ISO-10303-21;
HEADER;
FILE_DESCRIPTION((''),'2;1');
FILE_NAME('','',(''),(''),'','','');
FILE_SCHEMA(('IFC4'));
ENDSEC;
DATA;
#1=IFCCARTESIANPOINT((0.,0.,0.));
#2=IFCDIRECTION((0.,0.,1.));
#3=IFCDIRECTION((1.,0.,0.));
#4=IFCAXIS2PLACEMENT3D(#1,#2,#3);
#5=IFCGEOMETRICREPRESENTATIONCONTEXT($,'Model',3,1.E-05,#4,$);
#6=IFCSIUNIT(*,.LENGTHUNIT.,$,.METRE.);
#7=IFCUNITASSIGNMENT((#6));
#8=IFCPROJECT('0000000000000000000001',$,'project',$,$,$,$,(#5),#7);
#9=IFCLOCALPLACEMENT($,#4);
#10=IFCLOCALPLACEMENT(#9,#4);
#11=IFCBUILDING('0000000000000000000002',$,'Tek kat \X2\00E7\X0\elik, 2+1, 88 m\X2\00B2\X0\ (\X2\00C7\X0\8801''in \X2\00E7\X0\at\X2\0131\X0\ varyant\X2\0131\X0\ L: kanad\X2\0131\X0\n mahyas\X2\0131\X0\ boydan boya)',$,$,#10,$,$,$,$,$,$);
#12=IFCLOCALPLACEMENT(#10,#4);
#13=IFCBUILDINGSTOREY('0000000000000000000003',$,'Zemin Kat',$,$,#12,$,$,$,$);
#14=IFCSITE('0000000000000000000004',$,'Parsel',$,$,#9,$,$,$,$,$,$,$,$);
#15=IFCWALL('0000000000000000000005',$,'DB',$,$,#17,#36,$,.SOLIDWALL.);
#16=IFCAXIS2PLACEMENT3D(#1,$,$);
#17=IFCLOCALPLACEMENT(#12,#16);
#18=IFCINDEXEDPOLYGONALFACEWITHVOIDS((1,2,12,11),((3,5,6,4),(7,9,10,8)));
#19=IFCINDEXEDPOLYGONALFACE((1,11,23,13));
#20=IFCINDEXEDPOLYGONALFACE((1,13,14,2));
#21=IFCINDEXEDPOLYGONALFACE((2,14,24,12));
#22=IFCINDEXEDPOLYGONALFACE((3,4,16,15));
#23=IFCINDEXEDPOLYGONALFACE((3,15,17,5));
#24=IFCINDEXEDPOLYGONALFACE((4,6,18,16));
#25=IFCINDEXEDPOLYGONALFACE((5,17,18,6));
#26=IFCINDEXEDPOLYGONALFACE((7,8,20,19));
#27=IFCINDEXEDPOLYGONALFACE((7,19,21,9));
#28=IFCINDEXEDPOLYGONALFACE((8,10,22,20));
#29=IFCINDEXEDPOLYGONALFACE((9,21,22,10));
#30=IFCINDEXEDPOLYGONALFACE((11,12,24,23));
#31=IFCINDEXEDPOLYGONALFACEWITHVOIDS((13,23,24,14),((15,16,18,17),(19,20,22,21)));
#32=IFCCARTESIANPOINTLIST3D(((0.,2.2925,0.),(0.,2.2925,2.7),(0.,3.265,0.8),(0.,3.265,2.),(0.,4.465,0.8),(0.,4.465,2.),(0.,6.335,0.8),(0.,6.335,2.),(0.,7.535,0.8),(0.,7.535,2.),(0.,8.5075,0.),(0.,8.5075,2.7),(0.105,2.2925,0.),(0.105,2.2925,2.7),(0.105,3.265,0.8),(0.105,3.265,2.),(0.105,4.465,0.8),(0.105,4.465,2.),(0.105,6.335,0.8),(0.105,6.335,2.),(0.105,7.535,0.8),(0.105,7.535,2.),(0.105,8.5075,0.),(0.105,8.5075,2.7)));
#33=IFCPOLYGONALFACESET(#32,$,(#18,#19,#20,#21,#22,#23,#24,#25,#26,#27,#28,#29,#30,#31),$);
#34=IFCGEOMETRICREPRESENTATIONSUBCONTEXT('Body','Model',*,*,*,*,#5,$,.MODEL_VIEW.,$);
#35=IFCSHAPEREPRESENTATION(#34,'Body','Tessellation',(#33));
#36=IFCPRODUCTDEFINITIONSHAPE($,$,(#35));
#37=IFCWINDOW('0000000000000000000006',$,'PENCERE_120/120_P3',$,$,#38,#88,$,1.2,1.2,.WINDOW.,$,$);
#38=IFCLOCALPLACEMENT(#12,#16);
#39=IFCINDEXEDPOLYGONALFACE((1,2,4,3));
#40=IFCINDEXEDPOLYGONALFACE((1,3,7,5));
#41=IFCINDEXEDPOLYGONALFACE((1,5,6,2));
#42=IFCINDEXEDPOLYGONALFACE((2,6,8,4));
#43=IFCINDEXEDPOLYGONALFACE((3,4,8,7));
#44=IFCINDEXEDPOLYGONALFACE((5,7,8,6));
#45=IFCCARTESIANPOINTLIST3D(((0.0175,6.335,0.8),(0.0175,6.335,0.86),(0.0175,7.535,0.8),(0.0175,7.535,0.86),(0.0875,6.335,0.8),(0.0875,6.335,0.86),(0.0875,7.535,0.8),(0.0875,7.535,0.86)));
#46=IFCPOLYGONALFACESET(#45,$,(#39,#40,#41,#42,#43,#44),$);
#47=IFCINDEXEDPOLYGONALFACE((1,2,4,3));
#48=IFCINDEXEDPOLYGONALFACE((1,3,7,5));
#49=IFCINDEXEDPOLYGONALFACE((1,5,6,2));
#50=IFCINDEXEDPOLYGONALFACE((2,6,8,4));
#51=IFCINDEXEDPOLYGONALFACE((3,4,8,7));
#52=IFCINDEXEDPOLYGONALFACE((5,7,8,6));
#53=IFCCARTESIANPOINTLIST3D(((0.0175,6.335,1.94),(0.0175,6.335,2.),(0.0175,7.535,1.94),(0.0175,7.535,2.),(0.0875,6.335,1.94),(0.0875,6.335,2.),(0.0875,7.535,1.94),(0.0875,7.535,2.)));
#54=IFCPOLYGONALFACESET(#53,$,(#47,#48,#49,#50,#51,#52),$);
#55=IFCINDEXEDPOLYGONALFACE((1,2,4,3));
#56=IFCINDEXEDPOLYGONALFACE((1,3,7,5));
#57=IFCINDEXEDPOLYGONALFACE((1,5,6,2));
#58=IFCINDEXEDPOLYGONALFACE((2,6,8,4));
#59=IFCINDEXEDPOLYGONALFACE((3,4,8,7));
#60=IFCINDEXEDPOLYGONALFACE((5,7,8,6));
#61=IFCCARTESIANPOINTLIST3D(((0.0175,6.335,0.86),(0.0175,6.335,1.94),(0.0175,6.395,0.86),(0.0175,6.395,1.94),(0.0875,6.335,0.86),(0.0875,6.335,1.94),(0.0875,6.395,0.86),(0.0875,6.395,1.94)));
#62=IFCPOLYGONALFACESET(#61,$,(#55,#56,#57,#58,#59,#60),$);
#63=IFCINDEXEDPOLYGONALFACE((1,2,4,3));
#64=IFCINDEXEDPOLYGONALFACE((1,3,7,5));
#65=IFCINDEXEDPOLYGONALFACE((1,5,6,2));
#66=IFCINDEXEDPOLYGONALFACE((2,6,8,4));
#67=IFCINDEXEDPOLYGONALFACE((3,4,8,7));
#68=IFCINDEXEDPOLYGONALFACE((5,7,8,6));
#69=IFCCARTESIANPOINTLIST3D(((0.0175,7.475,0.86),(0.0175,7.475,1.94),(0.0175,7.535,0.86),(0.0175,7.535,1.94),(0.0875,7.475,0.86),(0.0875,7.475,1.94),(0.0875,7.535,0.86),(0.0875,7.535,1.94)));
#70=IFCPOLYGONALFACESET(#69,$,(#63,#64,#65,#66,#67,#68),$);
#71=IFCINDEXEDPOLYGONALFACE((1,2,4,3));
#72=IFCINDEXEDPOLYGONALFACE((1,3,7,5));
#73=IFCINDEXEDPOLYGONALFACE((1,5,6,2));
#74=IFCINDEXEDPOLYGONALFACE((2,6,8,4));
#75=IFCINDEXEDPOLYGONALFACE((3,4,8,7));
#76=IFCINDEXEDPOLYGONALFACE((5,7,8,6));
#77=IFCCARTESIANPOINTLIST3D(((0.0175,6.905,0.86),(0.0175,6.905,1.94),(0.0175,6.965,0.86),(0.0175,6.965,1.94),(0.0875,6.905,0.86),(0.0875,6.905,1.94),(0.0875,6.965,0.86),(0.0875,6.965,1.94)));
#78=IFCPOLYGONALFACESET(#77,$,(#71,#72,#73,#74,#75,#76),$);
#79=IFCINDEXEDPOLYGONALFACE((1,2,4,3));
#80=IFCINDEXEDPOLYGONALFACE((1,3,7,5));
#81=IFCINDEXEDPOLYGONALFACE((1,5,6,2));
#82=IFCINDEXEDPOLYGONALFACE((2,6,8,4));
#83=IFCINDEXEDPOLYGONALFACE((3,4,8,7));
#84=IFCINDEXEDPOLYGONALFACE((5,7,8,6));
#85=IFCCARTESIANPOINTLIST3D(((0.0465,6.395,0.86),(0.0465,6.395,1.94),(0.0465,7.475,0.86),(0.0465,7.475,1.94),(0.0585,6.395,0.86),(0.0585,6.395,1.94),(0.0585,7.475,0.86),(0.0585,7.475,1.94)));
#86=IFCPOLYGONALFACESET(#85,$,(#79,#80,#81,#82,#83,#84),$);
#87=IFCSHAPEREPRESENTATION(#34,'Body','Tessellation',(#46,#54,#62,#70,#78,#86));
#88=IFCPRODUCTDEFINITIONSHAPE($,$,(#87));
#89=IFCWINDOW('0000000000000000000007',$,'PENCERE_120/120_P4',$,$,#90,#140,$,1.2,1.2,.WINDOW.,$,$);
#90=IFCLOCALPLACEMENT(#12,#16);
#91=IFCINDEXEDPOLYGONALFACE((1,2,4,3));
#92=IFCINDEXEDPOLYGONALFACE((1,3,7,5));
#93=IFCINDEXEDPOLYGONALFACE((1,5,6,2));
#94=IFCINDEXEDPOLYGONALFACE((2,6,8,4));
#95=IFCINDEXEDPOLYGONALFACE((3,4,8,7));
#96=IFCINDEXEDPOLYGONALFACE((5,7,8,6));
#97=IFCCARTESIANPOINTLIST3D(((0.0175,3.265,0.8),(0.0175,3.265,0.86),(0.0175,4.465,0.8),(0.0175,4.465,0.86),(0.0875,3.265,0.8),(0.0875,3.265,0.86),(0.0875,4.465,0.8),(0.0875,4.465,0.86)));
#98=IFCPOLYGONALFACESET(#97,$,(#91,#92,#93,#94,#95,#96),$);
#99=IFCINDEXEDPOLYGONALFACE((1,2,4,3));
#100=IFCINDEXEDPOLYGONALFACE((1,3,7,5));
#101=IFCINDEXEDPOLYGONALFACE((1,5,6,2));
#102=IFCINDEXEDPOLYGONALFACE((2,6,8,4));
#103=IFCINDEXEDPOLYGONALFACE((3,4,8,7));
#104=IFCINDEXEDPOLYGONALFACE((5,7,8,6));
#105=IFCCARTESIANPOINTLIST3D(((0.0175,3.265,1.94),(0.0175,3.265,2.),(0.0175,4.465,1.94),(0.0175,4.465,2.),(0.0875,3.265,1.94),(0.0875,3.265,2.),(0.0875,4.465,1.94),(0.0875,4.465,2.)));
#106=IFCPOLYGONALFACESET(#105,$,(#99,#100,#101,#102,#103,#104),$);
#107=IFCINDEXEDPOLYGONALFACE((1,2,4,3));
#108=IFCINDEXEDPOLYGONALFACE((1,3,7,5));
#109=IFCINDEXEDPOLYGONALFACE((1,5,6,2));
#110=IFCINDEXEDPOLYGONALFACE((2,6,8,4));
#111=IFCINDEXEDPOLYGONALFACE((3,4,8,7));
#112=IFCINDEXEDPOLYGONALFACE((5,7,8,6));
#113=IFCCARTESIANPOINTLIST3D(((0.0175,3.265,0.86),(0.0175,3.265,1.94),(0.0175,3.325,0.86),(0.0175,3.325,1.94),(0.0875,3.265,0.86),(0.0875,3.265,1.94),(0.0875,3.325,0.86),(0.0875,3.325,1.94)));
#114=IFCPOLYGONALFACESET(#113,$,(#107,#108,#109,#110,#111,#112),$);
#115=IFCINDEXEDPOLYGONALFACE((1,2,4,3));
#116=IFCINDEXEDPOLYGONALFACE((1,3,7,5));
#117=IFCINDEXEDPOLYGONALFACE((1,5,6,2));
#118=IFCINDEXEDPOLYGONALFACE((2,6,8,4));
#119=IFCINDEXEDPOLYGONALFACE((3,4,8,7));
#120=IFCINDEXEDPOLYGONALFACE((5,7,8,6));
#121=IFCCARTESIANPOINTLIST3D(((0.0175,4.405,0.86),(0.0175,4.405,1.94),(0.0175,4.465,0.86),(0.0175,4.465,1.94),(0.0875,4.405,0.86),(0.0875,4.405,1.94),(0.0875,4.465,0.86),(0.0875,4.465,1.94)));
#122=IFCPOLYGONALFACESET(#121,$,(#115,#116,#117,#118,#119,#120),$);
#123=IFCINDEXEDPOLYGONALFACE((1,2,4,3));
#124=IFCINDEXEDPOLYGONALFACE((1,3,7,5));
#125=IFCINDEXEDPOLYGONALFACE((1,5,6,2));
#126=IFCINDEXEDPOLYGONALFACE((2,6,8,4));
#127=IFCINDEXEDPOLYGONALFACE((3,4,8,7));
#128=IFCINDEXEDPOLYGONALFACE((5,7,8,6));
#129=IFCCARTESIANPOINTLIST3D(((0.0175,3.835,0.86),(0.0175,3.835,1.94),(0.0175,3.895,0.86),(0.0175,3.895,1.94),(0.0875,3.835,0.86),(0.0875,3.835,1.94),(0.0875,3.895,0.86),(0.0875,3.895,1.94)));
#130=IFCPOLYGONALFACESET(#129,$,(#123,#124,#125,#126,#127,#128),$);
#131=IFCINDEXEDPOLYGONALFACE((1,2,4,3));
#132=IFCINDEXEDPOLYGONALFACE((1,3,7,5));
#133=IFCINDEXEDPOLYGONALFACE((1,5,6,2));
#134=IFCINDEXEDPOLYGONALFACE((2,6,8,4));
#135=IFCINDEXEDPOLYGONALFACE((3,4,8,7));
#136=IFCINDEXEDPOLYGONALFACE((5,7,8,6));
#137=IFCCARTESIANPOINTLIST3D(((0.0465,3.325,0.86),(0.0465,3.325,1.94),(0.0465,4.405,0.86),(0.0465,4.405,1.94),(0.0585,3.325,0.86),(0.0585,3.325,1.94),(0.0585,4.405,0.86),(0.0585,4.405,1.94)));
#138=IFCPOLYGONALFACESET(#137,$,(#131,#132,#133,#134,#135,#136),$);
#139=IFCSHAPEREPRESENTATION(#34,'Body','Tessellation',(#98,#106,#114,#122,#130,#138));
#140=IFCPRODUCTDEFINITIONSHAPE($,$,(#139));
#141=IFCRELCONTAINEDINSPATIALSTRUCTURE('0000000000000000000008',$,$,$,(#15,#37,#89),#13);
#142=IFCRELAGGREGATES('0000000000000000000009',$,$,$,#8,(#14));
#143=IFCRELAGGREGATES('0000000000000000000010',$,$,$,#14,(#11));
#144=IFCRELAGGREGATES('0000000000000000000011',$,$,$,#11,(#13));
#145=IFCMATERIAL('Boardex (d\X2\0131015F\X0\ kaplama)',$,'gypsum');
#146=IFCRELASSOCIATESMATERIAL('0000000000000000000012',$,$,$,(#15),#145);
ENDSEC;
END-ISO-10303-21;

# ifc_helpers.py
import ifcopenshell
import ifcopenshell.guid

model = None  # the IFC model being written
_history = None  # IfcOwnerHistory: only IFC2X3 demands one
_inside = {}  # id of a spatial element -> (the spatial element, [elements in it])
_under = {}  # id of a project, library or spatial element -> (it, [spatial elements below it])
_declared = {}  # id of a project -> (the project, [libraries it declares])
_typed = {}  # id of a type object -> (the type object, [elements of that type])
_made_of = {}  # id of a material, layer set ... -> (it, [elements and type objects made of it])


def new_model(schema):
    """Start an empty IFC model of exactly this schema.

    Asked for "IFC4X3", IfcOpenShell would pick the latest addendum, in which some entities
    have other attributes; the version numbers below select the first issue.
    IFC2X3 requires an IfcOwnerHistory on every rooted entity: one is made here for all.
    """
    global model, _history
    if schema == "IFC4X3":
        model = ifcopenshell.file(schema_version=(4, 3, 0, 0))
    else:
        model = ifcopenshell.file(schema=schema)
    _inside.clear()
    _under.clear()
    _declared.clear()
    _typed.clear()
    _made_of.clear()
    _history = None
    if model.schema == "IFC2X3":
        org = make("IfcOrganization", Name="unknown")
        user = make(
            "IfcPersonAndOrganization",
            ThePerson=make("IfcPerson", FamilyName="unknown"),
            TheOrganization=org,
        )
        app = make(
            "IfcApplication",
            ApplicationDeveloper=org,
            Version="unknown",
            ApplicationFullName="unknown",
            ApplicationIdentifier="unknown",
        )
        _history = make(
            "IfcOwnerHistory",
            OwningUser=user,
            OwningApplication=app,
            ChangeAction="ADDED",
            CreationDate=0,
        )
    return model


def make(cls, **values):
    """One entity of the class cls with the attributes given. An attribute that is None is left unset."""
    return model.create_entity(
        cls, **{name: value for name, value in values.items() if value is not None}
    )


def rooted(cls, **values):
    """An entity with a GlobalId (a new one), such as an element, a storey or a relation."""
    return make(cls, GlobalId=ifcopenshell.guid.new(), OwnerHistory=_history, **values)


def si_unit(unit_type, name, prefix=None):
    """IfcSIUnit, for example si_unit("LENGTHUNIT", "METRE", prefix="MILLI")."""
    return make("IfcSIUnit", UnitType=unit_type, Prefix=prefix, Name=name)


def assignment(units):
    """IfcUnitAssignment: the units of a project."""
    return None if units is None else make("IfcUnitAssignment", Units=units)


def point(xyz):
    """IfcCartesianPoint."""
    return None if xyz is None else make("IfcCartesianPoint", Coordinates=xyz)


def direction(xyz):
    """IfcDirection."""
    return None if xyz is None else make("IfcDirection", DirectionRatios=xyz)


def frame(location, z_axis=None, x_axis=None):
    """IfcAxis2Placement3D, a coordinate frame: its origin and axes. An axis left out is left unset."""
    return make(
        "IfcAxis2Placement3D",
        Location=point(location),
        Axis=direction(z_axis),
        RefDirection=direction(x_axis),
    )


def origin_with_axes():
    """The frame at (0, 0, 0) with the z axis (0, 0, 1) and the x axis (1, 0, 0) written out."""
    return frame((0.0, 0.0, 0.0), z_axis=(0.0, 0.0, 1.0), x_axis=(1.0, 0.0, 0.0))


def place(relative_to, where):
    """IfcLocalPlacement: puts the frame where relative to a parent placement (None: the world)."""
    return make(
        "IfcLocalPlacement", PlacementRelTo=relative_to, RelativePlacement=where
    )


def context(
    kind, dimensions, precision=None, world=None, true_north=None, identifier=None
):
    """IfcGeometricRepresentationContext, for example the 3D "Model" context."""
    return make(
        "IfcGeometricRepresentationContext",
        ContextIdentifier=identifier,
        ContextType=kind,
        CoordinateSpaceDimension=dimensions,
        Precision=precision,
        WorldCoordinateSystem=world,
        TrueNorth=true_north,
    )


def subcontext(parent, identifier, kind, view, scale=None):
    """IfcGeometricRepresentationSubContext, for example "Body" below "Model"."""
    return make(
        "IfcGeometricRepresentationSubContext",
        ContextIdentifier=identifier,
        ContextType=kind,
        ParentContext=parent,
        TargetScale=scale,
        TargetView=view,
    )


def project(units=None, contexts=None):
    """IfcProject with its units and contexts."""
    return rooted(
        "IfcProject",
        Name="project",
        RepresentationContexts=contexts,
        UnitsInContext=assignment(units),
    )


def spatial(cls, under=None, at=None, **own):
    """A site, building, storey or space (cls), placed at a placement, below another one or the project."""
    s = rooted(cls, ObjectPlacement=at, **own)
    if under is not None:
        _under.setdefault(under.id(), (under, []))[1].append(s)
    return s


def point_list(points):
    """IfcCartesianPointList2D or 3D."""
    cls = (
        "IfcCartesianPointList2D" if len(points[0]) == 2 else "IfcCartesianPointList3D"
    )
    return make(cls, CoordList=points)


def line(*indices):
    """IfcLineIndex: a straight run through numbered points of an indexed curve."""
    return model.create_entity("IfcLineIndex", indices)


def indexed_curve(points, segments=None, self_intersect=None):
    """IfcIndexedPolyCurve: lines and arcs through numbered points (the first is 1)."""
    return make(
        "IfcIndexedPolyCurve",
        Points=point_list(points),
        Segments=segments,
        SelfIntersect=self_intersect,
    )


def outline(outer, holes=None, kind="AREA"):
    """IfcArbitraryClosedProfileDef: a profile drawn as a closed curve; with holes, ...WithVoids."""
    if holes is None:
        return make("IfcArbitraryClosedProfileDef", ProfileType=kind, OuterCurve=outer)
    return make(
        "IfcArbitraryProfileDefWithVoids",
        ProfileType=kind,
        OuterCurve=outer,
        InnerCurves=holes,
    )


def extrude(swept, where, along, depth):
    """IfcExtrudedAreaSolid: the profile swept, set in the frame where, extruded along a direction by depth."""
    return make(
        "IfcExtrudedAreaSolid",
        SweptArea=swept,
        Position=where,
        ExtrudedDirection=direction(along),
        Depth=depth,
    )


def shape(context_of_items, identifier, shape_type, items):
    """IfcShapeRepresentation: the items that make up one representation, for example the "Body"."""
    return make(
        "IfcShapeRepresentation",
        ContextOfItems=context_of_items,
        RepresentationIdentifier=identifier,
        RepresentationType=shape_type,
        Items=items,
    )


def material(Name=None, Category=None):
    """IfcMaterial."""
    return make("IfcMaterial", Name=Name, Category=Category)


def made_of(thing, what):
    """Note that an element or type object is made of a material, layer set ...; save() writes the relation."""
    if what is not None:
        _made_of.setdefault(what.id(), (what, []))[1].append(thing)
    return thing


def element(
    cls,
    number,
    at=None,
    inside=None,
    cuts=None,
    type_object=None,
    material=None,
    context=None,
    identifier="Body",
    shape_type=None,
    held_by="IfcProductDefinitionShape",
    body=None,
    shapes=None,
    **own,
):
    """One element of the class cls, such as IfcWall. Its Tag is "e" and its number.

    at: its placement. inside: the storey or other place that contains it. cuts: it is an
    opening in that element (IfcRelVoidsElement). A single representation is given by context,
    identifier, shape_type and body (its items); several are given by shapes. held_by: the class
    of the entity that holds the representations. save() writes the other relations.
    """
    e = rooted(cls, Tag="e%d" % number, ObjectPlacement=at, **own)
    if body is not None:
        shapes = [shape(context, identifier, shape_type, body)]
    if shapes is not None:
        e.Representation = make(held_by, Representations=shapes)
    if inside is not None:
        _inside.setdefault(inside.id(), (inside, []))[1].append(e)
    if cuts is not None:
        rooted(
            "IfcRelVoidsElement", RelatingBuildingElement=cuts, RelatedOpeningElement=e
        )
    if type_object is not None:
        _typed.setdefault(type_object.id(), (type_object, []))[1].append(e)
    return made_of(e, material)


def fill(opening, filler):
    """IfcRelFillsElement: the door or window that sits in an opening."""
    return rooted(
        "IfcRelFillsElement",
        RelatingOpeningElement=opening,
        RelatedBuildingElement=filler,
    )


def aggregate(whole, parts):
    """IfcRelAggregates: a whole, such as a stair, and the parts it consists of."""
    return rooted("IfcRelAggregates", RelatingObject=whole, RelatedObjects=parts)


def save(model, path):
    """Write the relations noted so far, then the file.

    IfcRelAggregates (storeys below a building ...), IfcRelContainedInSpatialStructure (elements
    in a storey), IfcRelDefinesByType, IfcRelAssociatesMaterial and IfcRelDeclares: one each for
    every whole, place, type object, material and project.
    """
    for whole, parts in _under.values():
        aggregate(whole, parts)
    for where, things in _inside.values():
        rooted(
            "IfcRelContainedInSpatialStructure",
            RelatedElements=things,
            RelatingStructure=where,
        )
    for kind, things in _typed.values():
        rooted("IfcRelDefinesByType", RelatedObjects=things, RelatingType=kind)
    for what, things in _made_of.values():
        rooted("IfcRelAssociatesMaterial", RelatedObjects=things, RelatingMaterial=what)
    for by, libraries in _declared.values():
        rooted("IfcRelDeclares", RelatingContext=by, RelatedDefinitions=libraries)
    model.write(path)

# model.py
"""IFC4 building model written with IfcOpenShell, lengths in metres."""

from ifc_helpers import new_model, si_unit, frame, origin_with_axes, place, context, subcontext, project, spatial, line, indexed_curve, outline, extrude, material, element, fill, save


model = new_model("IFC4")

# Units and contexts
model_context = context("Model", 3, precision=1e-05, world=origin_with_axes())
body_context = subcontext(model_context, "Body", "Model", "MODEL_VIEW")
ifc_project = project(units=[si_unit("LENGTHUNIT", "METRE")], contexts=[model_context])

# Site, building, storey
site_placement = place(None, origin_with_axes())
site = spatial("IfcSite", under=ifc_project, at=site_placement, Name="Parsel")
building_placement = place(site_placement, origin_with_axes())
building = spatial("IfcBuilding", under=site, at=building_placement, Name="Tek kat çelik, 2+1, 88 m² (Ç8801'in çatı varyantı L: kanadın mahyası boydan boya)")
storey_placement = place(building_placement, origin_with_axes())
storey = spatial("IfcBuildingStorey", under=building, at=storey_placement, Name="Zemin Kat")

# Shared definitions
ifc_material = material(Name="Boardex (dış kaplama)", Category="gypsum")

# Wall, openings, windows
wall_1_placement = place(storey_placement, origin_with_axes())
wall_1 = element("IfcWall", 1, at=wall_1_placement, inside=storey, material=ifc_material, Name="DB", PredefinedType="SOLIDWALL", context=body_context, shape_type="SweptSolid", body=[
    extrude(outline(indexed_curve([(0.0, 0.0), (0.105, 0.0), (0.105, 6.215), (0.0, 6.215)], segments=[line(1, 2, 3, 4, 1)])), frame((0.0, 2.2925, 0.0), z_axis=(0.0, 0.0, 1.0), x_axis=(1.0, 0.0, 0.0)), (0.0, 0.0, 1.0), 2.7),
])
opening_1_placement = place(wall_1_placement, origin_with_axes())
opening_1 = element("IfcOpeningElement", 2, at=opening_1_placement, cuts=wall_1, PredefinedType="OPENING", context=body_context, shape_type="SweptSolid", body=[
    extrude(outline(indexed_curve([(0.0, 0.0), (0.145, 0.0), (0.145, 1.2), (0.0, 1.2)], segments=[line(1, 2, 3, 4, 1)])), frame((-0.02, 6.335, 0.8), z_axis=(0.0, 0.0, 1.0), x_axis=(1.0, 0.0, 0.0)), (0.0, 0.0, 1.0), 1.2),
])
opening_2_placement = place(wall_1_placement, origin_with_axes())
opening_2 = element("IfcOpeningElement", 3, at=opening_2_placement, cuts=wall_1, PredefinedType="OPENING", context=body_context, shape_type="SweptSolid", body=[
    extrude(outline(indexed_curve([(0.0, 0.0), (0.145, 0.0), (0.145, 1.2), (0.0, 1.2)], segments=[line(1, 2, 3, 4, 1)])), frame((-0.02, 3.265, 0.8), z_axis=(0.0, 0.0, 1.0), x_axis=(1.0, 0.0, 0.0)), (0.0, 0.0, 1.0), 1.2),
])
window_1_placement = place(storey_placement, origin_with_axes())
window_1 = element("IfcWindow", 4, at=window_1_placement, inside=storey, Name="PENCERE_120/120_P3", OverallHeight=1.2, OverallWidth=1.2, PredefinedType="WINDOW", context=body_context, shape_type="SweptSolid", body=[
    extrude(outline(indexed_curve([(0.0, 0.0), (0.07, 0.0), (0.07, 1.2), (0.0, 1.2)], segments=[line(1, 2, 3, 4, 1)])), frame((0.0175, 6.335, 0.8), z_axis=(0.0, 0.0, 1.0), x_axis=(1.0, 0.0, 0.0)), (0.0, 0.0, 1.0), 0.06),
    extrude(outline(indexed_curve([(0.0, 0.0), (0.07, 0.0), (0.07, 1.2), (0.0, 1.2)], segments=[line(1, 2, 3, 4, 1)])), frame((0.0175, 6.335, 1.94), z_axis=(0.0, 0.0, 1.0), x_axis=(1.0, 0.0, 0.0)), (0.0, 0.0, 1.0), 0.06),
    extrude(outline(indexed_curve([(0.0, 0.0), (0.07, 0.0), (0.07, 0.06), (0.0, 0.06)], segments=[line(1, 2, 3, 4, 1)])), frame((0.0175, 6.335, 0.86), z_axis=(0.0, 0.0, 1.0), x_axis=(1.0, 0.0, 0.0)), (0.0, 0.0, 1.0), 1.08),
    extrude(outline(indexed_curve([(0.0, 0.0), (0.07, 0.0), (0.07, 0.06), (0.0, 0.06)], segments=[line(1, 2, 3, 4, 1)])), frame((0.0175, 7.475, 0.86), z_axis=(0.0, 0.0, 1.0), x_axis=(1.0, 0.0, 0.0)), (0.0, 0.0, 1.0), 1.08),
    extrude(outline(indexed_curve([(0.0, 0.0), (0.07, 0.0), (0.07, 0.06), (0.0, 0.06)], segments=[line(1, 2, 3, 4, 1)])), frame((0.0175, 6.905, 0.86), z_axis=(0.0, 0.0, 1.0), x_axis=(1.0, 0.0, 0.0)), (0.0, 0.0, 1.0), 1.08),
    extrude(outline(indexed_curve([(0.0, 0.0), (0.012, 0.0), (0.012, 1.08), (0.0, 1.08)], segments=[line(1, 2, 3, 4, 1)])), frame((0.0465, 6.395, 0.86), z_axis=(0.0, 0.0, 1.0), x_axis=(1.0, 0.0, 0.0)), (0.0, 0.0, 1.0), 1.08),
])
fill(opening_1, window_1)
window_2_placement = place(storey_placement, origin_with_axes())
window_2 = element("IfcWindow", 5, at=window_2_placement, inside=storey, Name="PENCERE_120/120_P4", OverallHeight=1.2, OverallWidth=1.2, PredefinedType="WINDOW", context=body_context, shape_type="SweptSolid", body=[
    extrude(outline(indexed_curve([(0.0, 0.0), (0.07, 0.0), (0.07, 1.2), (0.0, 1.2)], segments=[line(1, 2, 3, 4, 1)])), frame((0.0175, 3.265, 0.8), z_axis=(0.0, 0.0, 1.0), x_axis=(1.0, 0.0, 0.0)), (0.0, 0.0, 1.0), 0.06),
    extrude(outline(indexed_curve([(0.0, 0.0), (0.07, 0.0), (0.07, 1.2), (0.0, 1.2)], segments=[line(1, 2, 3, 4, 1)])), frame((0.0175, 3.265, 1.94), z_axis=(0.0, 0.0, 1.0), x_axis=(1.0, 0.0, 0.0)), (0.0, 0.0, 1.0), 0.06),
    extrude(outline(indexed_curve([(0.0, 0.0), (0.07, 0.0), (0.07, 0.06), (0.0, 0.06)], segments=[line(1, 2, 3, 4, 1)])), frame((0.0175, 3.265, 0.86), z_axis=(0.0, 0.0, 1.0), x_axis=(1.0, 0.0, 0.0)), (0.0, 0.0, 1.0), 1.08),
    extrude(outline(indexed_curve([(0.0, 0.0), (0.07, 0.0), (0.07, 0.06), (0.0, 0.06)], segments=[line(1, 2, 3, 4, 1)])), frame((0.0175, 4.405, 0.86), z_axis=(0.0, 0.0, 1.0), x_axis=(1.0, 0.0, 0.0)), (0.0, 0.0, 1.0), 1.08),
    extrude(outline(indexed_curve([(0.0, 0.0), (0.07, 0.0), (0.07, 0.06), (0.0, 0.06)], segments=[line(1, 2, 3, 4, 1)])), frame((0.0175, 3.835, 0.86), z_axis=(0.0, 0.0, 1.0), x_axis=(1.0, 0.0, 0.0)), (0.0, 0.0, 1.0), 1.08),
    extrude(outline(indexed_curve([(0.0, 0.0), (0.012, 0.0), (0.012, 1.08), (0.0, 1.08)], segments=[line(1, 2, 3, 4, 1)])), frame((0.0465, 3.325, 0.86), z_axis=(0.0, 0.0, 1.0), x_axis=(1.0, 0.0, 0.0)), (0.0, 0.0, 1.0), 1.08),
])
fill(opening_2, window_2)

save(model, "model.ifc")
